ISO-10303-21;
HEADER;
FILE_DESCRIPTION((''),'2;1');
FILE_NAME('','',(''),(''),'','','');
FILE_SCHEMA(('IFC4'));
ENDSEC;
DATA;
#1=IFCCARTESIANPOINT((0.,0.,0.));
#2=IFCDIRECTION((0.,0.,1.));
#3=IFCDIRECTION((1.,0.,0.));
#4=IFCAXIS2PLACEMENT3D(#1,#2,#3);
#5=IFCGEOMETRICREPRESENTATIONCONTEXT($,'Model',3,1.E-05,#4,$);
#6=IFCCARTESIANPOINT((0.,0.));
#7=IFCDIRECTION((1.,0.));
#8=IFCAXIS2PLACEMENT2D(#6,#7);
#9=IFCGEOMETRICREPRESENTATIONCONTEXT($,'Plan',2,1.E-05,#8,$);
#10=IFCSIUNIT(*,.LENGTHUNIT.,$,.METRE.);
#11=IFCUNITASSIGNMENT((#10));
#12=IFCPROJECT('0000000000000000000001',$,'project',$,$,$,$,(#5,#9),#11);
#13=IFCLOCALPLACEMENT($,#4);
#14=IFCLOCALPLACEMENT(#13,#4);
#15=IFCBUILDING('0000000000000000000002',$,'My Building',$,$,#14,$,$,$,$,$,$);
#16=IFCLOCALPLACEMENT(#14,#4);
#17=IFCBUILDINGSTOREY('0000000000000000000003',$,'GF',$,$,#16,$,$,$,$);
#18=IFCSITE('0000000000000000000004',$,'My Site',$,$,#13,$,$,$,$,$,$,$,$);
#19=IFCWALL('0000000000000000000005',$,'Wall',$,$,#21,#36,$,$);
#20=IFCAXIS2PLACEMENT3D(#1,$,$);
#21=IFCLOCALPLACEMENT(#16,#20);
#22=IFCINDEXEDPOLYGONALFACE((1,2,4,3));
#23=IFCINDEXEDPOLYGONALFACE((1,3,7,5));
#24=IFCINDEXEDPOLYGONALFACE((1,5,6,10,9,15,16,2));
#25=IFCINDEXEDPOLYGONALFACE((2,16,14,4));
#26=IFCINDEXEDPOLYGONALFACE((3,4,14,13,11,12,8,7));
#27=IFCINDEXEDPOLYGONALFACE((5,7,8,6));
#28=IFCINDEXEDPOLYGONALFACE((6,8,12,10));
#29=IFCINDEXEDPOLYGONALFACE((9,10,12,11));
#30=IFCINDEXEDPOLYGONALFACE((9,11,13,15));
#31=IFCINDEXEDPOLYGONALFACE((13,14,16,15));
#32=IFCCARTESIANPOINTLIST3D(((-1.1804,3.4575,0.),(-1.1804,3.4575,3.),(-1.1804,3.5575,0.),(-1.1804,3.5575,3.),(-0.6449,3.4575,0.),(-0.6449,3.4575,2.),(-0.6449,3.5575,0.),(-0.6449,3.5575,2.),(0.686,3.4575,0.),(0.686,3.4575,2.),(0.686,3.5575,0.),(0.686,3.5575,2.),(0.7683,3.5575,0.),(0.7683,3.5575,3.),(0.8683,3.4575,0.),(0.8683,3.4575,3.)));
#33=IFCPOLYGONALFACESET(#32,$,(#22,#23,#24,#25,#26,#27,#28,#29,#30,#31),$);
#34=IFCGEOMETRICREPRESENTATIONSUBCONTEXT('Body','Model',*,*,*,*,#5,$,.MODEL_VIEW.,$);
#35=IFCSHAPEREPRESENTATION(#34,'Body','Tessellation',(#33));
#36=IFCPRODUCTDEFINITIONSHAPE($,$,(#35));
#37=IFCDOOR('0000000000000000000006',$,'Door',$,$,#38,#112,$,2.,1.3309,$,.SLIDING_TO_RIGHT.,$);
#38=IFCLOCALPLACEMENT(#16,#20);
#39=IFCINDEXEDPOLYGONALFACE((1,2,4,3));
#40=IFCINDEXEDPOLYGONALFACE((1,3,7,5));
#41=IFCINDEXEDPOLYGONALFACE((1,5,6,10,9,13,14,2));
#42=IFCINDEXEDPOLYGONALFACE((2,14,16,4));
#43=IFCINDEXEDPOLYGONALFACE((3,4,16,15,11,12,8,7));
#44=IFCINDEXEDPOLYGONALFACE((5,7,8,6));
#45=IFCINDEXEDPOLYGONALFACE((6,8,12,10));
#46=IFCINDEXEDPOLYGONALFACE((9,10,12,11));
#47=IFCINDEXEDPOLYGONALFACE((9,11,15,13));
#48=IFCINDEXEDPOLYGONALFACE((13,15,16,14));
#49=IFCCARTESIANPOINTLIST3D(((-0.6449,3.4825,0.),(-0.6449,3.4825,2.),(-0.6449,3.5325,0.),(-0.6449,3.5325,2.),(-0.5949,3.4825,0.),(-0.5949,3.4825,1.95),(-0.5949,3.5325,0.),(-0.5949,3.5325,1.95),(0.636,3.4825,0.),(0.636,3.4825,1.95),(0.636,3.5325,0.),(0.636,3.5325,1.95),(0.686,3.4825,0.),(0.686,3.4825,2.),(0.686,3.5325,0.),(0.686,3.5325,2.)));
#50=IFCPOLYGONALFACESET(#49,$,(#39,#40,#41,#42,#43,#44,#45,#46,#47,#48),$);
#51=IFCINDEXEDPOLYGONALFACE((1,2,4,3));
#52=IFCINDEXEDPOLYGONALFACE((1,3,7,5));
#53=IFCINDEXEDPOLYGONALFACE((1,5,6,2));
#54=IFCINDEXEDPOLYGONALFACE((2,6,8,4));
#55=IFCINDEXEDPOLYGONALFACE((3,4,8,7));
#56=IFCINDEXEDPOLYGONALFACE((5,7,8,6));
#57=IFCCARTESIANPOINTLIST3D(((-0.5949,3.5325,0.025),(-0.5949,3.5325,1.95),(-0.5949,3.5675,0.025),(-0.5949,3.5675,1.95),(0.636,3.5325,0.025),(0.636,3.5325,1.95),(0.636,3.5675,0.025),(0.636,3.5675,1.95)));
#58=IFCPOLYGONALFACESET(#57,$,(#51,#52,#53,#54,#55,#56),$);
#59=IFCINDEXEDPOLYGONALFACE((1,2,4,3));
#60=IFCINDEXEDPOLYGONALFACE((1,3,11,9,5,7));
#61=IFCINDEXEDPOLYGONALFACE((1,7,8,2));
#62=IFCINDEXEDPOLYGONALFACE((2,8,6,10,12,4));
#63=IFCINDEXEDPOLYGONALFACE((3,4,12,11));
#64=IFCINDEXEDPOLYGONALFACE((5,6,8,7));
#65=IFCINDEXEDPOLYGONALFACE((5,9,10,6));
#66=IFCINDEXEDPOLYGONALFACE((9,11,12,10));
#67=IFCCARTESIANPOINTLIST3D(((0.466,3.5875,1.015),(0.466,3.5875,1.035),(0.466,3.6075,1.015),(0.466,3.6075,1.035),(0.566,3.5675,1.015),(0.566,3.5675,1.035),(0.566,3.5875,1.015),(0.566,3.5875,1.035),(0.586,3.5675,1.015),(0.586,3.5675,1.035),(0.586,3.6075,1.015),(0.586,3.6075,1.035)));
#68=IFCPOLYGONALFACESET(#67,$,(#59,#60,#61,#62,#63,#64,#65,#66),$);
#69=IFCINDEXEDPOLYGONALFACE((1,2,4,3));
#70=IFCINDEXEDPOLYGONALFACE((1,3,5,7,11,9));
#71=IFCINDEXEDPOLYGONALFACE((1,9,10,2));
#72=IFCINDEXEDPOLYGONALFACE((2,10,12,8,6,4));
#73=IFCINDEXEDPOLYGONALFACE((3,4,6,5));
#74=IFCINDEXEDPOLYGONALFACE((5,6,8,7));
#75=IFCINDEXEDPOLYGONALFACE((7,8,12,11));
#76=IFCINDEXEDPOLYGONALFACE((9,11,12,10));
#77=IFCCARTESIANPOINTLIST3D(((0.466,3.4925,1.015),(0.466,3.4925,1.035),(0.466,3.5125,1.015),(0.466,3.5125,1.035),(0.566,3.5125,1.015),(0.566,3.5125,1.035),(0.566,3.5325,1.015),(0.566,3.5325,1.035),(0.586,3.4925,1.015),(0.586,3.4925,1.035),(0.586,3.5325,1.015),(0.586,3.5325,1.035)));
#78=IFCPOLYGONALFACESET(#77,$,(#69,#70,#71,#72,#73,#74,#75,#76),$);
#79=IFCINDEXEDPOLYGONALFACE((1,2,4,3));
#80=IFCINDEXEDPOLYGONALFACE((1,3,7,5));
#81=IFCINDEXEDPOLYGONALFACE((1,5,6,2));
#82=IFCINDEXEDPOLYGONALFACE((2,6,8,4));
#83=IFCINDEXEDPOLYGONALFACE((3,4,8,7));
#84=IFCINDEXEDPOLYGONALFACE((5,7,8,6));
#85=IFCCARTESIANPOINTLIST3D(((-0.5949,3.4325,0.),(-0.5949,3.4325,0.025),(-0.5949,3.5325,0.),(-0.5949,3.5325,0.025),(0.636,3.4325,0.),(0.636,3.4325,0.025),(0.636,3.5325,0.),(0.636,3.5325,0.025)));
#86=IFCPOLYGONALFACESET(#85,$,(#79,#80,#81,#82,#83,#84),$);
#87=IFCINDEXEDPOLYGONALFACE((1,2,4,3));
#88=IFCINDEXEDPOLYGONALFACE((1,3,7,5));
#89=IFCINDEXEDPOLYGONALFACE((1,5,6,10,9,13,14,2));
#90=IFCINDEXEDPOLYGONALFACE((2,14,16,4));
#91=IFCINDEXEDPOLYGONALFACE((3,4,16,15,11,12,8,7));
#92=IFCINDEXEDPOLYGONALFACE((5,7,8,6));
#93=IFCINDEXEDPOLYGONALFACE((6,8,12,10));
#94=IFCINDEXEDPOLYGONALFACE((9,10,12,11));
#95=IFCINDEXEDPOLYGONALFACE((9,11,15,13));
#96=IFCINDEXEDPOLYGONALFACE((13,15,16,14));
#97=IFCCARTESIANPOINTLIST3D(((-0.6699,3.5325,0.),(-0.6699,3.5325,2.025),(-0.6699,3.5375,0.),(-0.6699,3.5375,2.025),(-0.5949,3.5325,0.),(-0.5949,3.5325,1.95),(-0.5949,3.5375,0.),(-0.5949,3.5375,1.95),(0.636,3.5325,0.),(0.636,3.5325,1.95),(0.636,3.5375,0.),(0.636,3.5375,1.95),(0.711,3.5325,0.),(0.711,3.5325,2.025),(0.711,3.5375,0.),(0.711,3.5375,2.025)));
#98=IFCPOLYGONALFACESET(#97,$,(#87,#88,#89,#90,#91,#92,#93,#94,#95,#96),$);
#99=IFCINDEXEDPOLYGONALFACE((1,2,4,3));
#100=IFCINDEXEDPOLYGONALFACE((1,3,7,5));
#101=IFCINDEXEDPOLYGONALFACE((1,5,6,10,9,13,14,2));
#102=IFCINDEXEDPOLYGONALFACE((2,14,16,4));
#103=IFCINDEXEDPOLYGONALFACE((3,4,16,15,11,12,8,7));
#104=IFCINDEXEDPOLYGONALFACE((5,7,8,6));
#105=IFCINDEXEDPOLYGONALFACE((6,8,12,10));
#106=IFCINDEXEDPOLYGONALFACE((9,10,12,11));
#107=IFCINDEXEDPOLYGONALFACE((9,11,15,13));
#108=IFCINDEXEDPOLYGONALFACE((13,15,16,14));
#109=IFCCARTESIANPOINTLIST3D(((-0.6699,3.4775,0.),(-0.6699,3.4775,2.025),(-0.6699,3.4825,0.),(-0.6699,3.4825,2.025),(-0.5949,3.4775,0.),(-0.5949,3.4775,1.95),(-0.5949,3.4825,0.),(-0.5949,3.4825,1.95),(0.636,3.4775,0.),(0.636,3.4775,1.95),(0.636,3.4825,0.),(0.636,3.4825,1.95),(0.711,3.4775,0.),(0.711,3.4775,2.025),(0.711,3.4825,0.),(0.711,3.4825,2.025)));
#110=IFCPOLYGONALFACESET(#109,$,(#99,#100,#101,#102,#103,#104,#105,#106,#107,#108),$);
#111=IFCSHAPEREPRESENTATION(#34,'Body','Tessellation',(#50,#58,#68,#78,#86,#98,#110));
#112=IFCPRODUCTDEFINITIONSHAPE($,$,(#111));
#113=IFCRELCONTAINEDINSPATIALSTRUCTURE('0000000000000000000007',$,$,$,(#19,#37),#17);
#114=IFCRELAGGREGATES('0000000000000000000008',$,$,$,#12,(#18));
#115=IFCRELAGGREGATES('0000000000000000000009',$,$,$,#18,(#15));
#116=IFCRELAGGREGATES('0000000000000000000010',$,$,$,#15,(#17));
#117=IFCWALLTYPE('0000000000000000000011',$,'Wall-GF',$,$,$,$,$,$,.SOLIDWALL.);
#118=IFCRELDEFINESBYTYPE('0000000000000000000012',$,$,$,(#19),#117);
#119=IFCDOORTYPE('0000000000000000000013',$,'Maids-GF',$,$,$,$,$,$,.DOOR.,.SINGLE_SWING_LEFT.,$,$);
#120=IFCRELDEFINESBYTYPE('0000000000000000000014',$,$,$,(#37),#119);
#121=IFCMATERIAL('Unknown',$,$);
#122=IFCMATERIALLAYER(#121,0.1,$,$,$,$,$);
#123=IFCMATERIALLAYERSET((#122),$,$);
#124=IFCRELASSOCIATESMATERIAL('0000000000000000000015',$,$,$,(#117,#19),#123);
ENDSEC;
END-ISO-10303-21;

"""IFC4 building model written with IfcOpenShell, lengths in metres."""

from ifc_helpers import new_model, entity, si_unit, frame, origin_with_axes, origin_2d_with_axis, place, context, subcontext, project, spatial, line, indexed_curve, outline, extrude, shape, source, transform, mapped, material, layer, layer_set, layer_usage, type_object, type_shapes, element, fill, save


model = new_model("IFC4")

# Units and contexts
model_context = context("Model", 3, precision=1e-05, world=origin_with_axes())
plan_context = context("Plan", 2, precision=1e-05, world=origin_2d_with_axis())
body_context_1 = subcontext(model_context, "Body", "Model", "MODEL_VIEW")
body_context_2 = subcontext(plan_context, "Body", "Plan", "PLAN_VIEW")
ifc_project = project(units=[si_unit("LENGTHUNIT", "METRE")], contexts=[model_context, plan_context])

# Site, building, storey
site_placement = place(None, origin_with_axes())
site = spatial("IfcSite", under=ifc_project, at=site_placement, Name="My Site")
building_placement = place(site_placement, origin_with_axes())
building = spatial("IfcBuilding", under=site, at=building_placement, Name="My Building")
storey_placement = place(building_placement, origin_with_axes())
storey = spatial("IfcBuildingStorey", under=building, at=storey_placement, Name="GF")

# Shared definitions
ifc_material_1 = material(Name="Unknown")

# Shared definitions
ifc_layer_1 = layer(ifc_material_1, 0.1)
ifc_layer_set_1 = layer_set([ifc_layer_1])
wall_type = type_object("IfcWallType", Name="Wall-GF", PredefinedType="SOLIDWALL", material=ifc_layer_set_1)

# Wall, opening, door
ifc_layer_usage_1 = layer_usage(ifc_layer_set_1, "AXIS2", "POSITIVE", 0.0)
wall_1_placement = place(storey_placement, frame((0.7683, 3.5575, 0.0), z_axis=(0.0, 0.0, 1.0), x_axis=(-1.0, 0.0, 0.0)))
wall_1 = element("IfcWall", 1, at=wall_1_placement, inside=storey, type_object=wall_type, material=ifc_layer_usage_1, Name="Wall", context=body_context_1, shape_type="SweptSolid", body=[
    extrude(outline(indexed_curve([(0.0, 0.0), (-0.1, 0.1), (1.9488, 0.1), (1.9488, 0.0)], segments=[line(1, 2, 3, 4, 1)])), origin_with_axes(), (0.0, 0.0, 1.0), 3.0),
])
shared_shape_1 = source(origin_with_axes(), body_context_1, "Body", "SweptSolid", [
    extrude(outline(indexed_curve([(0.0, 0.0), (1.3309, 0.0), (1.3309, 2.0), (0.0, 2.0)], segments=[line(1, 2, 3, 4, 1)])), frame((0.0, -0.6, 0.0), z_axis=(0.0, -1.0, 0.0), x_axis=(1.0, 0.0, 0.0)), (0.0, 0.0, -1.0), 1.2),
])
opening_1_placement = place(wall_1_placement, frame((0.0824, 0.025, 0.0), z_axis=(0.0, 0.0, 1.0), x_axis=(1.0, -0.000001, 0.0)))
opening_1 = element("IfcOpeningElement", 2, at=opening_1_placement, cuts=wall_1, PredefinedType="OPENING", context=body_context_1, shape_type="MappedRepresentation", body=[
    mapped(shared_shape_1, transform((0.0, 0.0, 0.0), x_axis=(1.0, 0.0, 0.0), y_axis=(0.0, 1.0, 0.0), z_axis=(0.0, 0.0, 1.0), scale=1.0)),
])
door_type_1 = type_object("IfcDoorType", Name="Maids-GF", OperationType="SINGLE_SWING_LEFT", PredefinedType="DOOR")
shared_shape_2 = source(origin_with_axes(), body_context_1, "Body", "SweptSolid", [
    extrude(outline(indexed_curve([(0.0, 0.0), (0.0, 2.0), (1.3309, 2.0), (1.3309, 0.0), (1.2809, 0.0), (1.2809, 1.95), (0.05, 1.95), (0.05, 0.0)], segments=[line(1, 2, 3, 4, 5, 6, 7, 8, 1)])), frame((0.0, 0.0, 0.0), z_axis=(0.0, -1.0, 0.0), x_axis=(1.0, 0.0, 0.0)), (0.0, 0.0, -1.0), 0.05),
    extrude(outline(indexed_curve([(0.0, 0.0), (1.2309, 0.0), (1.2309, 0.035), (0.0, 0.035)], segments=[line(1, 2, 3, 4, 1)])), frame((0.05, -0.035, 0.025), z_axis=(0.0, 0.0, 1.0), x_axis=(1.0, 0.0, 0.0)), (0.0, 0.0, 1.0), 1.925),
    extrude(outline(indexed_curve([(0.0, 0.0), (0.0, -0.04), (0.12, -0.04), (0.12, -0.02), (0.02, -0.02), (0.02, 0.0)], segments=[line(1, 2, 3, 4, 5, 6, 1)])), frame((0.1, -0.035, 1.015), z_axis=(0.0, 0.0, 1.0), x_axis=(1.0, 0.0, 0.0)), (0.0, 0.0, 1.0), 0.02),
    extrude(outline(indexed_curve([(0.0, 0.0), (0.0, 0.04), (0.12, 0.04), (0.12, 0.02), (0.02, 0.02), (0.02, 0.0)], segments=[line(1, 2, 3, 4, 5, 6, 1)])), frame((0.1, 0.0, 1.015), z_axis=(0.0, 0.0, 1.0), x_axis=(1.0, 0.0, 0.0)), (0.0, 0.0, 1.0), 0.02),
    extrude(outline(indexed_curve([(0.0, 0.0), (1.2309, 0.0), (1.2309, 0.1), (0.0, 0.1)], segments=[line(1, 2, 3, 4, 1)])), frame((0.05, 0.0, 0.0), z_axis=(0.0, 0.0, 1.0), x_axis=(1.0, 0.0, 0.0)), (0.0, 0.0, 1.0), 0.025),
    extrude(outline(indexed_curve([(0.0, 0.0), (0.0, 2.025), (1.3809, 2.025), (1.3809, 0.0), (1.3059, 0.0), (1.3059, 1.95), (0.075, 1.95), (0.075, 0.0)], segments=[line(1, 2, 3, 4, 5, 6, 7, 8, 1)])), frame((-0.025, -0.005, 0.0), z_axis=(0.0, -1.0, 0.0), x_axis=(1.0, 0.0, 0.0)), (0.0, 0.0, -1.0), 0.005),
    extrude(outline(indexed_curve([(0.0, 0.0), (0.0, 2.025), (1.3809, 2.025), (1.3809, 0.0), (1.3059, 0.0), (1.3059, 1.95), (0.075, 1.95), (0.075, 0.0)], segments=[line(1, 2, 3, 4, 5, 6, 7, 8, 1)])), frame((-0.025, 0.05, 0.0), z_axis=(0.0, -1.0, 0.0), x_axis=(1.0, 0.0, 0.0)), (0.0, 0.0, -1.0), 0.005),
])
shared_shape_3 = source(origin_with_axes(), body_context_2, "Body", "Curve2D", [
    entity("IfcIndexedPolyCurve", entity("IfcCartesianPointList2D", [[0.0, 0.0], [0.05, 0.0], [0.05, 0.05], [0.0, 0.05]]), [entity("IfcLineIndex", [1, 2, 3, 4, 1])]),
    entity("IfcIndexedPolyCurve", entity("IfcCartesianPointList2D", [[1.3309, 0.0], [1.2809, 0.0], [1.2809, 0.05], [1.3309, 0.05]]), [entity("IfcLineIndex", [1, 2, 3, 4, 1])]),
    entity("IfcIndexedPolyCurve", entity("IfcCartesianPointList2D", [[1.8964, -0.035], [0.6655, -0.035], [0.6655, 0.0], [1.8964, 0.0]]), [entity("IfcLineIndex", [1, 2, 3, 4, 1])]),
])
type_shapes(door_type_1, [shared_shape_2, shared_shape_3])
door_1_placement = place(opening_1_placement, frame((0.0, 0.0, 0.0), z_axis=(0.0, 0.0, 1.0), x_axis=(1.0, 0.0, 0.0)))
door_1 = element("IfcDoor", 3, at=door_1_placement, inside=storey, type_object=door_type_1, Name="Door", OperationType="SLIDING_TO_RIGHT", OverallHeight=2.0, OverallWidth=1.3309, shapes=[
    shape(body_context_1, "Body", "MappedRepresentation", [mapped(shared_shape_2, transform((0.0, 0.0, 0.0), x_axis=(1.0, 0.0, 0.0), y_axis=(0.0, 1.0, 0.0), z_axis=(0.0, 0.0, 1.0), scale=1.0))]),
    shape(body_context_2, "Body", "MappedRepresentation", [mapped(shared_shape_3, transform((0.0, 0.0, 0.0), x_axis=(1.0, 0.0, 0.0), y_axis=(0.0, 1.0, 0.0), z_axis=(0.0, 0.0, 1.0), scale=1.0))]),
])
fill(opening_1, door_1)

save(model, "model.ifc")
